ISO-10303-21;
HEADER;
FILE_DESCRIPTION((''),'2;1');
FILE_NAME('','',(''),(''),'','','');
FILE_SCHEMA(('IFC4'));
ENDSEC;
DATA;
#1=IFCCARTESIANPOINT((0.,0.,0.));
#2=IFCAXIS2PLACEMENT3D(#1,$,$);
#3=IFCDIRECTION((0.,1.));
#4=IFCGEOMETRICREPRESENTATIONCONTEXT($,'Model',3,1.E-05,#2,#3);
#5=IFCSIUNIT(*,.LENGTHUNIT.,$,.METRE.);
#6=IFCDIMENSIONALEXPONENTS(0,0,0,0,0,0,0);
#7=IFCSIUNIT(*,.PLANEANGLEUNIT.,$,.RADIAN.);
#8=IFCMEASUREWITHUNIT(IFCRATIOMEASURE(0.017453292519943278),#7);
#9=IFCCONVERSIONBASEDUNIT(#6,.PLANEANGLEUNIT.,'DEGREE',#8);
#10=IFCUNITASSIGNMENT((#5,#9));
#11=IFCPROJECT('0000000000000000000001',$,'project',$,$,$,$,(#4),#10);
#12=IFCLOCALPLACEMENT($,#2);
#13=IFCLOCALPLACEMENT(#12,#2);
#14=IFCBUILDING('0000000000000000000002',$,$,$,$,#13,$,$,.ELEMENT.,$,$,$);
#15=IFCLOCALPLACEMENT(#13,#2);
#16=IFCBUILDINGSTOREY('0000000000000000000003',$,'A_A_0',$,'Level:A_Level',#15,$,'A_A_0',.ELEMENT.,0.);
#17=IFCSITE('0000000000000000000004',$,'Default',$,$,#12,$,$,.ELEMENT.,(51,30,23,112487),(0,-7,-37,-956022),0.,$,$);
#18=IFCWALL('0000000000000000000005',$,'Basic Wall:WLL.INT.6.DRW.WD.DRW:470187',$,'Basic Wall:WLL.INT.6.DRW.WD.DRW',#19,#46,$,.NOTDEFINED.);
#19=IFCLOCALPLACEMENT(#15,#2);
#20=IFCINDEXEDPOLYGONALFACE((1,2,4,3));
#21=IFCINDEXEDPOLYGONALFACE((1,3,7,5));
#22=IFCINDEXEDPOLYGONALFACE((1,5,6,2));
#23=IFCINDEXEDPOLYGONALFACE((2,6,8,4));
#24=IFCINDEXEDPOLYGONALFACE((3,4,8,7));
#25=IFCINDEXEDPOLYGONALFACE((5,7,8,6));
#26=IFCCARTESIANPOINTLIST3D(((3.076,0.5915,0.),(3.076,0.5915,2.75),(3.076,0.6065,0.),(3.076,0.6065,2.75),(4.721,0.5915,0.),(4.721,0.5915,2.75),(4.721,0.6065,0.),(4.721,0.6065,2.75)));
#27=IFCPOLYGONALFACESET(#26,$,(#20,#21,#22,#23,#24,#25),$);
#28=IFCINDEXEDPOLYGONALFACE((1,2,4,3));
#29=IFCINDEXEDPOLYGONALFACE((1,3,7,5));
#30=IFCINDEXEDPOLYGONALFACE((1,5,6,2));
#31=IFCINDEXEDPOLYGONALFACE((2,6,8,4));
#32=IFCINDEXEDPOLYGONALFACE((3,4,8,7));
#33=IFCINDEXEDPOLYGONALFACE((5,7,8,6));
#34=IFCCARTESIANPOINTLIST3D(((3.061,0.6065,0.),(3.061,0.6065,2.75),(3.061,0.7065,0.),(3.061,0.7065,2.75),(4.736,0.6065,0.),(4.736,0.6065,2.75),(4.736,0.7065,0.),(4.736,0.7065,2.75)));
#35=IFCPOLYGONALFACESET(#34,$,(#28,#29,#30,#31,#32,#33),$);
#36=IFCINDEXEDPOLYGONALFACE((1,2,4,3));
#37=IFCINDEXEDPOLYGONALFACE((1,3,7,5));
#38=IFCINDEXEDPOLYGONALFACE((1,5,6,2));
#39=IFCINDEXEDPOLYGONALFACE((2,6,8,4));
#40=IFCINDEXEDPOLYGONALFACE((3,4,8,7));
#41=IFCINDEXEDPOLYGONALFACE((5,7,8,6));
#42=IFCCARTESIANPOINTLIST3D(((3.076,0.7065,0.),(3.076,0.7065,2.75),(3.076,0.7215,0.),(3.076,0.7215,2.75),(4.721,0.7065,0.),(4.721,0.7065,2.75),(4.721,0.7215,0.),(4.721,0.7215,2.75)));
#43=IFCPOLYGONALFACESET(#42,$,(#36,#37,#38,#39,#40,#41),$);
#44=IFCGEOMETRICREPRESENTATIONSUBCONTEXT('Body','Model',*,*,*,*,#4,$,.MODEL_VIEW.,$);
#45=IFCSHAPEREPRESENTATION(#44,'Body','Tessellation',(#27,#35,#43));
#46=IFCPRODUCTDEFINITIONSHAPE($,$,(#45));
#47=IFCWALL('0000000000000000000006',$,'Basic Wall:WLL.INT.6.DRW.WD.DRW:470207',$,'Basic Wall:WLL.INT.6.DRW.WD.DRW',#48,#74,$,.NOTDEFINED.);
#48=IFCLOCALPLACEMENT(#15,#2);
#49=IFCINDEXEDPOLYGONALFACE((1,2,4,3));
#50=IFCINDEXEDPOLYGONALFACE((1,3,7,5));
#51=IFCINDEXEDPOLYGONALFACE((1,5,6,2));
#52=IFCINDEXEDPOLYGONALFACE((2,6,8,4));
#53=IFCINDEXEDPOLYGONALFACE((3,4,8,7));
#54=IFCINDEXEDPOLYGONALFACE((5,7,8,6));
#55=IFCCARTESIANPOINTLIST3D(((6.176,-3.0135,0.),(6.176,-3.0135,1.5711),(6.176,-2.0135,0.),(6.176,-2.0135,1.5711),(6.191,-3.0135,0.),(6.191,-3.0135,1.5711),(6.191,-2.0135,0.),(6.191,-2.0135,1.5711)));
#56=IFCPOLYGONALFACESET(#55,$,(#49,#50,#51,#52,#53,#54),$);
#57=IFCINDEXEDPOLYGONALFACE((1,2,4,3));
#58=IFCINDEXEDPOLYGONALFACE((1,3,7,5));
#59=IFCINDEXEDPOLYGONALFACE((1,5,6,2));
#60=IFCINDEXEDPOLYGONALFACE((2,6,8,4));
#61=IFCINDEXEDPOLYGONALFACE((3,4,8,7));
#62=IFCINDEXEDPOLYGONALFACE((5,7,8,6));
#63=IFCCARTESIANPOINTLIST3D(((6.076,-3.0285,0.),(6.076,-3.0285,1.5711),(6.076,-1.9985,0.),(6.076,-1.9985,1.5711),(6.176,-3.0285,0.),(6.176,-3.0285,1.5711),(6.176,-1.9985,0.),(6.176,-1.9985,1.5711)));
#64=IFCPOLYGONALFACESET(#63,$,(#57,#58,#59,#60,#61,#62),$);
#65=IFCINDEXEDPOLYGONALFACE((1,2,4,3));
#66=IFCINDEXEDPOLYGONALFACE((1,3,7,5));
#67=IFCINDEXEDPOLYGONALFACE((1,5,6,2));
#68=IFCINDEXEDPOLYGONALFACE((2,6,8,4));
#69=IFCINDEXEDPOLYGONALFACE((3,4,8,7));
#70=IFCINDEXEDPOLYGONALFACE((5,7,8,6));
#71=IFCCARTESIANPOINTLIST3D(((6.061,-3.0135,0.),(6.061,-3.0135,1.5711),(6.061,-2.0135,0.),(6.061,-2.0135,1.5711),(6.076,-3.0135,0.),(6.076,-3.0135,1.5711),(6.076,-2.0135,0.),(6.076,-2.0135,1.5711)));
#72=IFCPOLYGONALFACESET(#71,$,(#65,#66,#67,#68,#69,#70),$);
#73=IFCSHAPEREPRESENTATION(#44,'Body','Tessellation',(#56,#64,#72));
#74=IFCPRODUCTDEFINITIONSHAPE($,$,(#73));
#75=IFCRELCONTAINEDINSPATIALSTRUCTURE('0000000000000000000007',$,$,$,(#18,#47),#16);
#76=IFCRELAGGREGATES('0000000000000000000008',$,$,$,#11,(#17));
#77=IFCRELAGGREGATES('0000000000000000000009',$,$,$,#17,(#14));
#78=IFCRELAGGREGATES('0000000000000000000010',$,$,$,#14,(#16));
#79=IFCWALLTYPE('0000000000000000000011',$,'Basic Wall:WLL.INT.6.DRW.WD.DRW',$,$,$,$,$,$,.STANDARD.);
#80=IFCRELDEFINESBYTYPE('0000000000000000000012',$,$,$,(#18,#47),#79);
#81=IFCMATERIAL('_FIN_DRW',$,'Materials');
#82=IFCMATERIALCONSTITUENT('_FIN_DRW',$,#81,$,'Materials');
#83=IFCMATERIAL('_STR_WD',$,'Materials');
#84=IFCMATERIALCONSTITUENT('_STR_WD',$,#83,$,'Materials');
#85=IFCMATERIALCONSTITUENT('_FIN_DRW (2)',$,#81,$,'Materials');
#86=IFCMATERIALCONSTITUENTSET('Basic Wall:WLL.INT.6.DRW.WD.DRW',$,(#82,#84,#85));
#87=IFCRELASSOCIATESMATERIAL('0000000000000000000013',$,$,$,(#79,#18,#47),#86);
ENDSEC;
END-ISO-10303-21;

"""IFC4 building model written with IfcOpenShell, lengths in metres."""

from ifc_helpers import new_model, entity, si_unit, converted_unit, direction, frame, origin, place, context, subcontext, project, spatial, indexed_curve, outline, extrude, material, constituent, constituent_set, type_object, element, save


model = new_model("IFC4")

# Units and contexts
model_context = context("Model", 3, precision=1e-05, world=origin(), true_north=direction((0.0, 1.0)))
body_context = subcontext(model_context, "Body", "Model", "MODEL_VIEW")
ifc_project = project(units=[si_unit("LENGTHUNIT", "METRE"), converted_unit("PLANEANGLEUNIT", "DEGREE", entity("IfcRatioMeasure", 0.017453292519943278), si_unit("PLANEANGLEUNIT", "RADIAN"), dimensions=[0, 0, 0, 0, 0, 0, 0])], contexts=[model_context])

# Site, building, storey
site_placement = place(None, origin())
site = spatial("IfcSite", under=ifc_project, at=site_placement, Name="Default", CompositionType="ELEMENT", RefLatitude=(51, 30, 23, 112487), RefLongitude=(0, -7, -37, -956022), RefElevation=0.0)
building_placement = place(site_placement, origin())
building = spatial("IfcBuilding", under=site, at=building_placement, CompositionType="ELEMENT")
storey_placement = place(building_placement, origin())
storey = spatial("IfcBuildingStorey", under=building, at=storey_placement, Name="A_A_0", ObjectType="Level:A_Level", LongName="A_A_0", CompositionType="ELEMENT", Elevation=0.0)

# Shared definitions
ifc_material_1 = material(Name="_FIN_DRW", Category="Materials")
ifc_material_2 = material(Name="_STR_WD", Category="Materials")

# Walls
ifc_constituent_1 = constituent(ifc_material_1, Name="_FIN_DRW", Category="Materials")
ifc_constituent_2 = constituent(ifc_material_2, Name="_STR_WD", Category="Materials")
ifc_constituent_3 = constituent(ifc_material_1, Name="_FIN_DRW (2)", Category="Materials")
ifc_constituent_set_1 = constituent_set(constituents=[ifc_constituent_1, ifc_constituent_2, ifc_constituent_3], Name="Basic Wall:WLL.INT.6.DRW.WD.DRW")
wall_type_1 = type_object("IfcWallType", Name="Basic Wall:WLL.INT.6.DRW.WD.DRW", PredefinedType="STANDARD", material=ifc_constituent_set_1)
wall_1_placement = place(storey_placement, frame((4.721, 0.6565, 0.0), z_axis=(0.0, 0.0, 1.0), x_axis=(-1.0, 0.0, 0.0)))
element("IfcWall", 1, at=wall_1_placement, inside=storey, type_object=wall_type_1, material=ifc_constituent_set_1, Name="Basic Wall:WLL.INT.6.DRW.WD.DRW:470187", ObjectType="Basic Wall:WLL.INT.6.DRW.WD.DRW", PredefinedType="NOTDEFINED", context=body_context, shape_type="SweptSolid", body=[
    extrude(outline(indexed_curve([(-0.0075, -0.8225), (0.0075, -0.8225), (0.0075, 0.8225), (-0.0075, 0.8225), (-0.0075, -0.8225)], self_intersect=False)), frame((0.8225, 0.0575, 0.0), z_axis=(0.0, 0.0, 1.0), x_axis=(0.0, -1.0, 0.0)), (0.0, 0.0, 1.0), 2.75),
    extrude(outline(indexed_curve([(-0.8375, -0.05), (0.8375, -0.05), (0.8375, 0.05), (-0.8375, 0.05), (-0.8375, -0.05)], self_intersect=False)), frame((0.8225, 0.0, 0.0)), (0.0, 0.0, 1.0), 2.75),
    extrude(outline(indexed_curve([(-0.0075, -0.8225), (0.0075, -0.8225), (0.0075, 0.8225), (-0.0075, 0.8225), (-0.0075, -0.8225)], self_intersect=False)), frame((0.8225, -0.0575, 0.0), z_axis=(0.0, 0.0, 1.0), x_axis=(0.0, 1.0, 0.0)), (0.0, 0.0, 1.0), 2.75),
])
wall_2_placement = place(storey_placement, frame((6.126, -2.0135, 0.0), z_axis=(0.0, 0.0, 1.0), x_axis=(0.0, -1.0, 0.0)))
element("IfcWall", 2, at=wall_2_placement, inside=storey, type_object=wall_type_1, material=ifc_constituent_set_1, Name="Basic Wall:WLL.INT.6.DRW.WD.DRW:470207", ObjectType="Basic Wall:WLL.INT.6.DRW.WD.DRW", PredefinedType="NOTDEFINED", context=body_context, shape_type="SweptSolid", body=[
    extrude(outline(indexed_curve([(-0.0075, -0.5), (0.0075, -0.5), (0.0075, 0.5), (-0.0075, 0.5), (-0.0075, -0.5)], self_intersect=False)), frame((0.5, 0.0575, 0.0), z_axis=(0.0, 0.0, 1.0), x_axis=(0.0, -1.0, 0.0)), (0.0, 0.0, 1.0), 1.5711),
    extrude(outline(indexed_curve([(-0.515, -0.05), (0.515, -0.05), (0.515, 0.05), (-0.515, 0.05), (-0.515, -0.05)], self_intersect=False)), frame((0.5, 0.0, 0.0)), (0.0, 0.0, 1.0), 1.5711),
    extrude(outline(indexed_curve([(-0.0075, -0.5), (0.0075, -0.5), (0.0075, 0.5), (-0.0075, 0.5), (-0.0075, -0.5)], self_intersect=False)), frame((0.5, -0.0575, 0.0), z_axis=(0.0, 0.0, 1.0), x_axis=(0.0, 1.0, 0.0)), (0.0, 0.0, 1.0), 1.5711),
])

save(model, "model.ifc")
